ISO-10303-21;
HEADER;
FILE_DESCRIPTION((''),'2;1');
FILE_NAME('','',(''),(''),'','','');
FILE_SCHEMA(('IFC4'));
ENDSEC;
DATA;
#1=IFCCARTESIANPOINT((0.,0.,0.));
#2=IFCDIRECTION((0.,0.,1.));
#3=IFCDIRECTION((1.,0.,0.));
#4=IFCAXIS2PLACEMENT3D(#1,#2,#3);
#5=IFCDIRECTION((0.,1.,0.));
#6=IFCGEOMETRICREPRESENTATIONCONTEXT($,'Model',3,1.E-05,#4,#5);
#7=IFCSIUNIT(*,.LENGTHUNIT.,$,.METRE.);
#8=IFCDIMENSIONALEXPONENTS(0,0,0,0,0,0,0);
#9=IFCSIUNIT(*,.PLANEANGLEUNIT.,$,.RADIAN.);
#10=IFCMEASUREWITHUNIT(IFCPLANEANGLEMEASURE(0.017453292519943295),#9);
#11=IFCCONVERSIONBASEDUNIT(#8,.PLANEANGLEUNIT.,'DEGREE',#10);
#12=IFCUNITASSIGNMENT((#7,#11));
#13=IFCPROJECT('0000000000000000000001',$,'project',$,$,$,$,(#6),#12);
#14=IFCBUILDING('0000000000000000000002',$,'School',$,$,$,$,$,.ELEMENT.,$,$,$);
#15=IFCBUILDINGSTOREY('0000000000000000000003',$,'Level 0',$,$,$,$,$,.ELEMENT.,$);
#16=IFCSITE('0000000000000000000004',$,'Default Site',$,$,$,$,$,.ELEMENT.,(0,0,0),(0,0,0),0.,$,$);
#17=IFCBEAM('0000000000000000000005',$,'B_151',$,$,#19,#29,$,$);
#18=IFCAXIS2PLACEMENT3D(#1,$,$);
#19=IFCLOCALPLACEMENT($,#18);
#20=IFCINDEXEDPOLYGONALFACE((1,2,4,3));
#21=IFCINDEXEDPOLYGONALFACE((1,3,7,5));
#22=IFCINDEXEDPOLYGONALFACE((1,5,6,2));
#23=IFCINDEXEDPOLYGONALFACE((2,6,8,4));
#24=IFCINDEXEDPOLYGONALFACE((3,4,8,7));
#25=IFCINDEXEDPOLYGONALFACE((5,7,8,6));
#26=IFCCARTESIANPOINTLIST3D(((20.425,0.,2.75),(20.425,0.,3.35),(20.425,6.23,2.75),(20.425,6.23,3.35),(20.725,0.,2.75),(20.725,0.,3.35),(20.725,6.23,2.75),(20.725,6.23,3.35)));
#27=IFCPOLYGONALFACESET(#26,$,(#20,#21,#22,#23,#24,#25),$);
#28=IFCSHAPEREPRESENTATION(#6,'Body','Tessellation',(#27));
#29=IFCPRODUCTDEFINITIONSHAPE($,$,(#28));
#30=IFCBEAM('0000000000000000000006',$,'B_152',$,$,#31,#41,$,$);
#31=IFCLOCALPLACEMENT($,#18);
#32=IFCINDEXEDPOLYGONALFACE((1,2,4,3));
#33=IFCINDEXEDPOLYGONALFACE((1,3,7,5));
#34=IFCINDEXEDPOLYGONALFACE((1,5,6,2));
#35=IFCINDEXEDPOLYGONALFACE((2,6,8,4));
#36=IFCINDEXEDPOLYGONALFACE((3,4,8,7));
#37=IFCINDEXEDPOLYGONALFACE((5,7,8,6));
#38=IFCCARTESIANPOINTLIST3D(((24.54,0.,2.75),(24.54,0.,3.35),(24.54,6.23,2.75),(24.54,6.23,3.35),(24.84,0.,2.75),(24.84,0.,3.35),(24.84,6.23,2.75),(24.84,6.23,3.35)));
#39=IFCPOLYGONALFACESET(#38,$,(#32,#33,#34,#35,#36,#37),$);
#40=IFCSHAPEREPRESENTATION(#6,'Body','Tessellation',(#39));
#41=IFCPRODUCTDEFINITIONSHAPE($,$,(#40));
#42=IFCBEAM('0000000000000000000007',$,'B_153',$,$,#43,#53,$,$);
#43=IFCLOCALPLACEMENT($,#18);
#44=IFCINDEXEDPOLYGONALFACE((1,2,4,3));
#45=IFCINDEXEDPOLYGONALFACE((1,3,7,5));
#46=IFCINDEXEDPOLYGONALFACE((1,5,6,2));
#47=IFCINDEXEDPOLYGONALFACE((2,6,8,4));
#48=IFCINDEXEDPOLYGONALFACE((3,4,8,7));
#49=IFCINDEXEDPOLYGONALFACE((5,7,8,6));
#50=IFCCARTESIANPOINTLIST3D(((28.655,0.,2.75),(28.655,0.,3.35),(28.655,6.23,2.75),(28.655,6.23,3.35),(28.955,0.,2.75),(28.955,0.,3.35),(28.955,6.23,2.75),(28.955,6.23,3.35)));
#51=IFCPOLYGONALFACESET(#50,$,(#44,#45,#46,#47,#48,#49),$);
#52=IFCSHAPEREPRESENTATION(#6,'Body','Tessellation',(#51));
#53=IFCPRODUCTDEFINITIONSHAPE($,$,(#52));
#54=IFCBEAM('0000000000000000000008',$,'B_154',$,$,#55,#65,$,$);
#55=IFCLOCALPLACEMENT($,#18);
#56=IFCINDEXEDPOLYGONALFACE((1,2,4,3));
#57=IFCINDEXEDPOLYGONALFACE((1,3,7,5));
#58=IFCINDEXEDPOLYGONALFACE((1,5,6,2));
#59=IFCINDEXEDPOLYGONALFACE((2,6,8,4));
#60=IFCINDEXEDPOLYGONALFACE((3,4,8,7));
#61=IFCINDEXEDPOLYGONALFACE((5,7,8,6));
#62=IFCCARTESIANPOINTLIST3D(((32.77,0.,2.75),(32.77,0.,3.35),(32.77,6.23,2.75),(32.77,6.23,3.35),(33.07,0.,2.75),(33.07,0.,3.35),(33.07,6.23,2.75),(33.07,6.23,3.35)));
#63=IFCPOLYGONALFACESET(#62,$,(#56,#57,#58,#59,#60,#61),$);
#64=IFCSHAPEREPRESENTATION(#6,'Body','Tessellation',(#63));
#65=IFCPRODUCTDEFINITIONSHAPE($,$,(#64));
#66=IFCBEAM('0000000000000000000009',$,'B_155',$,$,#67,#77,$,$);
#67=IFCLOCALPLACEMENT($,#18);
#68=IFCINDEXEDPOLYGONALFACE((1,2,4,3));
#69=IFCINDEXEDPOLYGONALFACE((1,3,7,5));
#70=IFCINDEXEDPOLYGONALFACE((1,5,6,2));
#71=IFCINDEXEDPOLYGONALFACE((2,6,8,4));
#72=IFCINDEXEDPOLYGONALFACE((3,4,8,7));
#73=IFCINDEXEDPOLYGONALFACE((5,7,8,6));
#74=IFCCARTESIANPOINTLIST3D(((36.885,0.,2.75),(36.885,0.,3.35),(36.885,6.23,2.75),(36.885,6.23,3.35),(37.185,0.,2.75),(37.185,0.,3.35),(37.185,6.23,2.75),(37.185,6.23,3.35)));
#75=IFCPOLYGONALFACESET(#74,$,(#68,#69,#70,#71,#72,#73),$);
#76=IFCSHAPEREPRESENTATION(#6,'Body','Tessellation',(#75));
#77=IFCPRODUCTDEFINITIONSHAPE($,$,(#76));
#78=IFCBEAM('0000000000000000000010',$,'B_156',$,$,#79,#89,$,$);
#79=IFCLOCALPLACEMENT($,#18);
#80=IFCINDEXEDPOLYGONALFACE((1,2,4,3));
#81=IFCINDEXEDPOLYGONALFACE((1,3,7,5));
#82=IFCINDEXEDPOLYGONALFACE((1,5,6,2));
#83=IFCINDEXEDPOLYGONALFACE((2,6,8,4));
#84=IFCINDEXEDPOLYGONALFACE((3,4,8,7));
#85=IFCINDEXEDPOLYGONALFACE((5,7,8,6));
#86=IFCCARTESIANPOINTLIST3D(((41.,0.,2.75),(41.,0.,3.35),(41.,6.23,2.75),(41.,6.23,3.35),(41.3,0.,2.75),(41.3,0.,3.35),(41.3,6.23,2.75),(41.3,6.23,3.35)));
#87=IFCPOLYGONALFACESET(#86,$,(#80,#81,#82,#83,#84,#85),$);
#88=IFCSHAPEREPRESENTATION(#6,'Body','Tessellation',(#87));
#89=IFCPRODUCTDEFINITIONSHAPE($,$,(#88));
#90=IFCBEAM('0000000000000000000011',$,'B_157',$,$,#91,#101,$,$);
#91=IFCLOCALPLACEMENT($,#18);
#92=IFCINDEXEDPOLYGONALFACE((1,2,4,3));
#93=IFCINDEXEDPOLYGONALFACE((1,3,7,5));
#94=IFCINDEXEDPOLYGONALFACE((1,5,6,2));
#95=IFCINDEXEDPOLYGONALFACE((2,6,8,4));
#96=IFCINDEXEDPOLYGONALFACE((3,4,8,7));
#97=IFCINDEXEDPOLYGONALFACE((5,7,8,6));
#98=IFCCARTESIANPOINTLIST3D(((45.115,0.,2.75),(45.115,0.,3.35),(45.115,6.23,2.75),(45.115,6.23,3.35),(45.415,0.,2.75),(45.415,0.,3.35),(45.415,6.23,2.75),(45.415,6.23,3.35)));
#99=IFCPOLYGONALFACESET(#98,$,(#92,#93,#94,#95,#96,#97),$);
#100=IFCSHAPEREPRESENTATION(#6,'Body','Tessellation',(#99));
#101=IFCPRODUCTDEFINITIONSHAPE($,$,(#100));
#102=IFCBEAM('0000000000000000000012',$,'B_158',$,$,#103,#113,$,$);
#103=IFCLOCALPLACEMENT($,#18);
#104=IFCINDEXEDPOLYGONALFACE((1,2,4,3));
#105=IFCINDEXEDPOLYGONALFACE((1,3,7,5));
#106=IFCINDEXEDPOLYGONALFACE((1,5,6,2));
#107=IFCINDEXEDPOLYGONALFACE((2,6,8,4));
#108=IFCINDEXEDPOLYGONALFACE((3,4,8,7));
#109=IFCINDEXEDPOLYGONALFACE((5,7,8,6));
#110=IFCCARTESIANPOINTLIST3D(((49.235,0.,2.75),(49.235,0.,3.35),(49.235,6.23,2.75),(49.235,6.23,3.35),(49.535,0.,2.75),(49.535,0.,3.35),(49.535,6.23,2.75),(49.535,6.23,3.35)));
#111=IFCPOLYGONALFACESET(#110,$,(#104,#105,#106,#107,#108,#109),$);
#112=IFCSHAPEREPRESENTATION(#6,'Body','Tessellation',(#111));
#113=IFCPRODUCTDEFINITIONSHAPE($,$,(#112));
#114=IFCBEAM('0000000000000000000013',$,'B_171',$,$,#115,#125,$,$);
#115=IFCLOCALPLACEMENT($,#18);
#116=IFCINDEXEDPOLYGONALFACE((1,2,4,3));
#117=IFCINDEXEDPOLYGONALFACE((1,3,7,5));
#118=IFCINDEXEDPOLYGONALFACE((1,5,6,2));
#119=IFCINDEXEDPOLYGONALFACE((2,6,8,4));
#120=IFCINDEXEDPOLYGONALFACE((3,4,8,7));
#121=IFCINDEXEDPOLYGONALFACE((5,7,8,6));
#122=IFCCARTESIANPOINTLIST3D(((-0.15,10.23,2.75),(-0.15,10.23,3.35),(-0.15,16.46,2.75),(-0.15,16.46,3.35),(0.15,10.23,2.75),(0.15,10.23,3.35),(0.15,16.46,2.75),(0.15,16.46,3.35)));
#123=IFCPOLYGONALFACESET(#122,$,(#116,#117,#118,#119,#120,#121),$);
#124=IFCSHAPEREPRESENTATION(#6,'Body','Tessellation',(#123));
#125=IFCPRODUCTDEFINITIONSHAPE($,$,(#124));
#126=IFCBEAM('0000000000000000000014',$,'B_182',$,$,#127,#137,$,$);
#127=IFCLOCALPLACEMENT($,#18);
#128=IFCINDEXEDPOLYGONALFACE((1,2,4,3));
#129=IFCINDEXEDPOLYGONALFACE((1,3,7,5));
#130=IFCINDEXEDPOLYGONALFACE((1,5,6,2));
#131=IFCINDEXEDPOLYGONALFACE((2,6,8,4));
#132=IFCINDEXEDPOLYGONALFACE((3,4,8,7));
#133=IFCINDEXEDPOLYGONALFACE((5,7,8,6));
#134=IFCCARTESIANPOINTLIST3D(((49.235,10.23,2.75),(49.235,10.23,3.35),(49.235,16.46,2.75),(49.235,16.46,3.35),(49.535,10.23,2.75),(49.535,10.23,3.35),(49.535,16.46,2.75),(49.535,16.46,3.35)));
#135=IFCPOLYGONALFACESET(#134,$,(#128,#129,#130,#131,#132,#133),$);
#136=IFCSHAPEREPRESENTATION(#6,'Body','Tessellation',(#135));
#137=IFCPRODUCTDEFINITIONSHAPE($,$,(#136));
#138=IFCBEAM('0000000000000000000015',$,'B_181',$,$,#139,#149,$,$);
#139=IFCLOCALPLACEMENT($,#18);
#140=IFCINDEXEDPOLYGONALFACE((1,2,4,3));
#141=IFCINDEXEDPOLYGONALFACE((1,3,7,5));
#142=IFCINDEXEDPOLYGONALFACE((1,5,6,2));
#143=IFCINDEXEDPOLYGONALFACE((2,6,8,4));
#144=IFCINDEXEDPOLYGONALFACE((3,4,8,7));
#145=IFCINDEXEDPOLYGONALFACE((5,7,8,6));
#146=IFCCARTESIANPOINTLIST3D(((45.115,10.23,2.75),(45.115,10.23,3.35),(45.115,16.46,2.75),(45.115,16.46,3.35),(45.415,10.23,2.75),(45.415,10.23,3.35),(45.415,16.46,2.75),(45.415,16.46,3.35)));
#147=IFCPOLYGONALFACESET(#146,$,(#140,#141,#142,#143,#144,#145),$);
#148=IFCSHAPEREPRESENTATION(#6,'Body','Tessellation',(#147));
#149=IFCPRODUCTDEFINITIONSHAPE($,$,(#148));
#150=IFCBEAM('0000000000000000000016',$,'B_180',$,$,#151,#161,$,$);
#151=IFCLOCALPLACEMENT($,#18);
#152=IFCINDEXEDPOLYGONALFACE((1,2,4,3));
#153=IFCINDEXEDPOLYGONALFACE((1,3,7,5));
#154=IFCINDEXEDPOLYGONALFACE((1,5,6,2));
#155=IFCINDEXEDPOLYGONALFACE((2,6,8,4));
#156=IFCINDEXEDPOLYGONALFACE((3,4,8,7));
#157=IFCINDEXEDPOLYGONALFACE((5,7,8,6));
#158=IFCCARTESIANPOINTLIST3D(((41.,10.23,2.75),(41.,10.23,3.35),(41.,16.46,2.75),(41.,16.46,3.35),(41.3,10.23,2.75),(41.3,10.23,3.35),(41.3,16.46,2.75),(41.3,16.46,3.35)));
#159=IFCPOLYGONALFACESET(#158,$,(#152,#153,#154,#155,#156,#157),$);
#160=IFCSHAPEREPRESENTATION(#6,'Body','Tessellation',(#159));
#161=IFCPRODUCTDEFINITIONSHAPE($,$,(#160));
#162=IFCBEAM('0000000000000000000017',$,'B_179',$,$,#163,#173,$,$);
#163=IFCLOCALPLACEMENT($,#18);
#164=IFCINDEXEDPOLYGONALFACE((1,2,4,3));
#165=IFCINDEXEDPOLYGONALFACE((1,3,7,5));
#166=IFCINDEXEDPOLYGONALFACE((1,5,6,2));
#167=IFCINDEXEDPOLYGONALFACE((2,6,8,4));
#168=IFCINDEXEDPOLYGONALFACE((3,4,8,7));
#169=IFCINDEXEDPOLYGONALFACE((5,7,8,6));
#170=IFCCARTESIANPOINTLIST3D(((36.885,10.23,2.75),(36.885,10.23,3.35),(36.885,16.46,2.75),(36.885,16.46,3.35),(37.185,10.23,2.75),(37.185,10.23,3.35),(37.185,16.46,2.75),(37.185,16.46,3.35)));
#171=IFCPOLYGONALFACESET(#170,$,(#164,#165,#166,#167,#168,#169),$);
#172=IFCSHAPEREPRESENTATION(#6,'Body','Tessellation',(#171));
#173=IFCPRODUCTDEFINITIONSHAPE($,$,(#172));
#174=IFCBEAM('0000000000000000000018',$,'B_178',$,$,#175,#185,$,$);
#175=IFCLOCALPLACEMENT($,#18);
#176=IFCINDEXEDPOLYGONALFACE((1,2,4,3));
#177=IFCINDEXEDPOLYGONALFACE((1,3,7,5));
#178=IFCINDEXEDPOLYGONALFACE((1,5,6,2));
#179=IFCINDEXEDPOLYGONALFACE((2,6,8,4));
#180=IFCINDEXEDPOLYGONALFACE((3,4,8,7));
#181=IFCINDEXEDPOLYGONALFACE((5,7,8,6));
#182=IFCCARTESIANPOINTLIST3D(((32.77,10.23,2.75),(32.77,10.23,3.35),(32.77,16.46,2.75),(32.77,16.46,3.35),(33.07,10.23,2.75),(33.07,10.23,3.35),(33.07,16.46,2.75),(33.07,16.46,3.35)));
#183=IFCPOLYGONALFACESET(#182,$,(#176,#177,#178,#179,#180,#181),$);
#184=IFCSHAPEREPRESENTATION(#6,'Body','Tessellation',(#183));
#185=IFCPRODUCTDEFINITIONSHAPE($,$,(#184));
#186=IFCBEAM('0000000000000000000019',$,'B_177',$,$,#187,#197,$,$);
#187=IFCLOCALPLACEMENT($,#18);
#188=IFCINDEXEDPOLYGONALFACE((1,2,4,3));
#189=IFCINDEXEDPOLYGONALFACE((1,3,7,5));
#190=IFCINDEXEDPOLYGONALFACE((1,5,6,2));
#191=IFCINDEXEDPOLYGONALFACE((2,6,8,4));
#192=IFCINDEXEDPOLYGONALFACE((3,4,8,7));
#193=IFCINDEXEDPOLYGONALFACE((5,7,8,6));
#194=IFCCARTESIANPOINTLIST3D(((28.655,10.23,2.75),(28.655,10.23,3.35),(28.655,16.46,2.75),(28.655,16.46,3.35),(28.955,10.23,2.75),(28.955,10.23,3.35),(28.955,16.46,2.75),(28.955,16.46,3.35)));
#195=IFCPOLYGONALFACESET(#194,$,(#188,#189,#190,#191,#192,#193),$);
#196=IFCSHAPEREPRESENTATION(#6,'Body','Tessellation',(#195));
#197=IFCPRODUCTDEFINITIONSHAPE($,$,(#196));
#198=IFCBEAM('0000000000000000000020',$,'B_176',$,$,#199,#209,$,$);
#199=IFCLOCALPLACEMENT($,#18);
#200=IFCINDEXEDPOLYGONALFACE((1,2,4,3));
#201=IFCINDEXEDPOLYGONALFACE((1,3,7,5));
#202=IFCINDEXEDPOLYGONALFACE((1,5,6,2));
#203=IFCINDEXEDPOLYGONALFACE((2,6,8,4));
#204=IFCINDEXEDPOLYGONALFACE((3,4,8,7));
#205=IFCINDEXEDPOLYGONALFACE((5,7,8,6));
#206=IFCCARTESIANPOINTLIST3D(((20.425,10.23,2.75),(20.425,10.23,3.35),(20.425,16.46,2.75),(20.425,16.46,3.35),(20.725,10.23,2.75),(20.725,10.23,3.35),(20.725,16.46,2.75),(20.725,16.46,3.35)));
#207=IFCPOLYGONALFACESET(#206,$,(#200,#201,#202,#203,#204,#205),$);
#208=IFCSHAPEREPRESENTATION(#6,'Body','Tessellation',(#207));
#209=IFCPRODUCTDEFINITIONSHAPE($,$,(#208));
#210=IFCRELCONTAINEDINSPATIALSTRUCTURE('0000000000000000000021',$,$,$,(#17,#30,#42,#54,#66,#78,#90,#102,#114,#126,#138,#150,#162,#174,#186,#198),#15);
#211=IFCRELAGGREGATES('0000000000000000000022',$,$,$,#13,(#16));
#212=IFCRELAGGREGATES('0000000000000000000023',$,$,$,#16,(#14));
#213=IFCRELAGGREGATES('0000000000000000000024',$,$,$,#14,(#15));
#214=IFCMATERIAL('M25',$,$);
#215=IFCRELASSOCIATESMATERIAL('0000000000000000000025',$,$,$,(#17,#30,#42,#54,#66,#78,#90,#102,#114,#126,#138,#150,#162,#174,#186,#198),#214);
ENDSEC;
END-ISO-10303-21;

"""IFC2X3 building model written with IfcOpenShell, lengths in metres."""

from ifc_helpers import new_model, entity, si_unit, converted_unit, direction, frame, frame_2d, origin_with_axes, place, context, project, spatial, rectangle, extrude, material, element, save


model = new_model("IFC2X3")

# Units and contexts
model_context = context("Model", 3, precision=1e-05, world=origin_with_axes(), true_north=direction((0.0, 1.0, 0.0)))
ifc_project = project(units=[si_unit("LENGTHUNIT", "METRE"), converted_unit("PLANEANGLEUNIT", "DEGREE", entity("IfcPlaneAngleMeasure", 0.017453292519943295), si_unit("PLANEANGLEUNIT", "RADIAN"), dimensions=[0, 0, 0, 0, 0, 0, 0])], contexts=[model_context])

# Site, building, storey
site = spatial("IfcSite", under=ifc_project, Name="Default Site", CompositionType="ELEMENT", RefLatitude=(0, 0, 0), RefLongitude=(0, 0, 0), RefElevation=0.0)
building = spatial("IfcBuilding", under=site, Name="School", CompositionType="ELEMENT")
storey = spatial("IfcBuildingStorey", under=building, Name="Level 0", CompositionType="ELEMENT")

# Beams
ifc_material = material(Name="M25")
placement = place(None, origin_with_axes())
element("IfcBeam", 1, at=placement, inside=storey, material=ifc_material, Name="B_151", context=model_context, shape_type="SweptSolid", body=[
    extrude(rectangle(XDim=0.3, YDim=0.6, at=frame_2d((0.0, 0.0), x_axis=(0.0, 1.0, 0.0))), frame((20.575, 0.0, 3.05), z_axis=(0.0, 1.0, 0.0), x_axis=(0.0, 0.0, -1.0)), (0.0, 0.0, 1.0), 6.23),
])
element("IfcBeam", 2, at=placement, inside=storey, material=ifc_material, Name="B_152", context=model_context, shape_type="SweptSolid", body=[
    extrude(rectangle(XDim=0.3, YDim=0.6, at=frame_2d((0.0, 0.0), x_axis=(0.0, 1.0, 0.0))), frame((24.69, 0.0, 3.05), z_axis=(0.0, 1.0, 0.0), x_axis=(0.0, 0.0, -1.0)), (0.0, 0.0, 1.0), 6.23),
])
element("IfcBeam", 3, at=placement, inside=storey, material=ifc_material, Name="B_153", context=model_context, shape_type="SweptSolid", body=[
    extrude(rectangle(XDim=0.3, YDim=0.6, at=frame_2d((0.0, 0.0), x_axis=(0.0, 1.0, 0.0))), frame((28.805, 0.0, 3.05), z_axis=(0.0, 1.0, 0.0), x_axis=(0.0, 0.0, -1.0)), (0.0, 0.0, 1.0), 6.23),
])
element("IfcBeam", 4, at=placement, inside=storey, material=ifc_material, Name="B_154", context=model_context, shape_type="SweptSolid", body=[
    extrude(rectangle(XDim=0.3, YDim=0.6, at=frame_2d((0.0, 0.0), x_axis=(0.0, 1.0, 0.0))), frame((32.92, 0.0, 3.05), z_axis=(0.0, 1.0, 0.0), x_axis=(0.0, 0.0, -1.0)), (0.0, 0.0, 1.0), 6.23),
])
element("IfcBeam", 5, at=placement, inside=storey, material=ifc_material, Name="B_155", context=model_context, shape_type="SweptSolid", body=[
    extrude(rectangle(XDim=0.3, YDim=0.6, at=frame_2d((0.0, 0.0), x_axis=(0.0, 1.0, 0.0))), frame((37.035, 0.0, 3.05), z_axis=(0.0, 1.0, 0.0), x_axis=(0.0, 0.0, -1.0)), (0.0, 0.0, 1.0), 6.23),
])
element("IfcBeam", 6, at=placement, inside=storey, material=ifc_material, Name="B_156", context=model_context, shape_type="SweptSolid", body=[
    extrude(rectangle(XDim=0.3, YDim=0.6, at=frame_2d((0.0, 0.0), x_axis=(0.0, 1.0, 0.0))), frame((41.15, 0.0, 3.05), z_axis=(0.0, 1.0, 0.0), x_axis=(0.0, 0.0, -1.0)), (0.0, 0.0, 1.0), 6.23),
])
element("IfcBeam", 7, at=placement, inside=storey, material=ifc_material, Name="B_157", context=model_context, shape_type="SweptSolid", body=[
    extrude(rectangle(XDim=0.3, YDim=0.6, at=frame_2d((0.0, 0.0), x_axis=(0.0, 1.0, 0.0))), frame((45.265, 0.0, 3.05), z_axis=(0.0, 1.0, 0.0), x_axis=(0.0, 0.0, -1.0)), (0.0, 0.0, 1.0), 6.23),
])
element("IfcBeam", 8, at=placement, inside=storey, material=ifc_material, Name="B_158", context=model_context, shape_type="SweptSolid", body=[
    extrude(rectangle(XDim=0.3, YDim=0.6, at=frame_2d((0.0, 0.0), x_axis=(0.0, 1.0, 0.0))), frame((49.385, 0.0, 3.05), z_axis=(0.0, 1.0, 0.0), x_axis=(0.0, 0.0, -1.0)), (0.0, 0.0, 1.0), 6.23),
])
element("IfcBeam", 9, at=placement, inside=storey, material=ifc_material, Name="B_171", context=model_context, shape_type="SweptSolid", body=[
    extrude(rectangle(XDim=0.3, YDim=0.6, at=frame_2d((0.0, 0.0), x_axis=(0.0, 1.0, 0.0))), frame((0.0, 10.23, 3.05), z_axis=(0.0, 1.0, 0.0), x_axis=(0.0, 0.0, -1.0)), (0.0, 0.0, 1.0), 6.23),
])
element("IfcBeam", 10, at=placement, inside=storey, material=ifc_material, Name="B_182", context=model_context, shape_type="SweptSolid", body=[
    extrude(rectangle(XDim=0.3, YDim=0.6, at=frame_2d((0.0, 0.0), x_axis=(0.0, 1.0, 0.0))), frame((49.385, 10.23, 3.05), z_axis=(0.0, 1.0, 0.0), x_axis=(0.0, 0.0, -1.0)), (0.0, 0.0, 1.0), 6.23),
])
element("IfcBeam", 11, at=placement, inside=storey, material=ifc_material, Name="B_181", context=model_context, shape_type="SweptSolid", body=[
    extrude(rectangle(XDim=0.3, YDim=0.6, at=frame_2d((0.0, 0.0), x_axis=(0.0, 1.0, 0.0))), frame((45.265, 10.23, 3.05), z_axis=(0.0, 1.0, 0.0), x_axis=(0.0, 0.0, -1.0)), (0.0, 0.0, 1.0), 6.23),
])
element("IfcBeam", 12, at=placement, inside=storey, material=ifc_material, Name="B_180", context=model_context, shape_type="SweptSolid", body=[
    extrude(rectangle(XDim=0.3, YDim=0.6, at=frame_2d((0.0, 0.0), x_axis=(0.0, 1.0, 0.0))), frame((41.15, 10.23, 3.05), z_axis=(0.0, 1.0, 0.0), x_axis=(0.0, 0.0, -1.0)), (0.0, 0.0, 1.0), 6.23),
])
element("IfcBeam", 13, at=placement, inside=storey, material=ifc_material, Name="B_179", context=model_context, shape_type="SweptSolid", body=[
    extrude(rectangle(XDim=0.3, YDim=0.6, at=frame_2d((0.0, 0.0), x_axis=(0.0, 1.0, 0.0))), frame((37.035, 10.23, 3.05), z_axis=(0.0, 1.0, 0.0), x_axis=(0.0, 0.0, -1.0)), (0.0, 0.0, 1.0), 6.23),
])
element("IfcBeam", 14, at=placement, inside=storey, material=ifc_material, Name="B_178", context=model_context, shape_type="SweptSolid", body=[
    extrude(rectangle(XDim=0.3, YDim=0.6, at=frame_2d((0.0, 0.0), x_axis=(0.0, 1.0, 0.0))), frame((32.92, 10.23, 3.05), z_axis=(0.0, 1.0, 0.0), x_axis=(0.0, 0.0, -1.0)), (0.0, 0.0, 1.0), 6.23),
])
element("IfcBeam", 15, at=placement, inside=storey, material=ifc_material, Name="B_177", context=model_context, shape_type="SweptSolid", body=[
    extrude(rectangle(XDim=0.3, YDim=0.6, at=frame_2d((0.0, 0.0), x_axis=(0.0, 1.0, 0.0))), frame((28.805, 10.23, 3.05), z_axis=(0.0, 1.0, 0.0), x_axis=(0.0, 0.0, -1.0)), (0.0, 0.0, 1.0), 6.23),
])
element("IfcBeam", 16, at=placement, inside=storey, material=ifc_material, Name="B_176", context=model_context, shape_type="SweptSolid", body=[
    extrude(rectangle(XDim=0.3, YDim=0.6, at=frame_2d((0.0, 0.0), x_axis=(0.0, 1.0, 0.0))), frame((20.575, 10.23, 3.05), z_axis=(0.0, 1.0, 0.0), x_axis=(0.0, 0.0, -1.0)), (0.0, 0.0, 1.0), 6.23),
])

save(model, "model.ifc")
